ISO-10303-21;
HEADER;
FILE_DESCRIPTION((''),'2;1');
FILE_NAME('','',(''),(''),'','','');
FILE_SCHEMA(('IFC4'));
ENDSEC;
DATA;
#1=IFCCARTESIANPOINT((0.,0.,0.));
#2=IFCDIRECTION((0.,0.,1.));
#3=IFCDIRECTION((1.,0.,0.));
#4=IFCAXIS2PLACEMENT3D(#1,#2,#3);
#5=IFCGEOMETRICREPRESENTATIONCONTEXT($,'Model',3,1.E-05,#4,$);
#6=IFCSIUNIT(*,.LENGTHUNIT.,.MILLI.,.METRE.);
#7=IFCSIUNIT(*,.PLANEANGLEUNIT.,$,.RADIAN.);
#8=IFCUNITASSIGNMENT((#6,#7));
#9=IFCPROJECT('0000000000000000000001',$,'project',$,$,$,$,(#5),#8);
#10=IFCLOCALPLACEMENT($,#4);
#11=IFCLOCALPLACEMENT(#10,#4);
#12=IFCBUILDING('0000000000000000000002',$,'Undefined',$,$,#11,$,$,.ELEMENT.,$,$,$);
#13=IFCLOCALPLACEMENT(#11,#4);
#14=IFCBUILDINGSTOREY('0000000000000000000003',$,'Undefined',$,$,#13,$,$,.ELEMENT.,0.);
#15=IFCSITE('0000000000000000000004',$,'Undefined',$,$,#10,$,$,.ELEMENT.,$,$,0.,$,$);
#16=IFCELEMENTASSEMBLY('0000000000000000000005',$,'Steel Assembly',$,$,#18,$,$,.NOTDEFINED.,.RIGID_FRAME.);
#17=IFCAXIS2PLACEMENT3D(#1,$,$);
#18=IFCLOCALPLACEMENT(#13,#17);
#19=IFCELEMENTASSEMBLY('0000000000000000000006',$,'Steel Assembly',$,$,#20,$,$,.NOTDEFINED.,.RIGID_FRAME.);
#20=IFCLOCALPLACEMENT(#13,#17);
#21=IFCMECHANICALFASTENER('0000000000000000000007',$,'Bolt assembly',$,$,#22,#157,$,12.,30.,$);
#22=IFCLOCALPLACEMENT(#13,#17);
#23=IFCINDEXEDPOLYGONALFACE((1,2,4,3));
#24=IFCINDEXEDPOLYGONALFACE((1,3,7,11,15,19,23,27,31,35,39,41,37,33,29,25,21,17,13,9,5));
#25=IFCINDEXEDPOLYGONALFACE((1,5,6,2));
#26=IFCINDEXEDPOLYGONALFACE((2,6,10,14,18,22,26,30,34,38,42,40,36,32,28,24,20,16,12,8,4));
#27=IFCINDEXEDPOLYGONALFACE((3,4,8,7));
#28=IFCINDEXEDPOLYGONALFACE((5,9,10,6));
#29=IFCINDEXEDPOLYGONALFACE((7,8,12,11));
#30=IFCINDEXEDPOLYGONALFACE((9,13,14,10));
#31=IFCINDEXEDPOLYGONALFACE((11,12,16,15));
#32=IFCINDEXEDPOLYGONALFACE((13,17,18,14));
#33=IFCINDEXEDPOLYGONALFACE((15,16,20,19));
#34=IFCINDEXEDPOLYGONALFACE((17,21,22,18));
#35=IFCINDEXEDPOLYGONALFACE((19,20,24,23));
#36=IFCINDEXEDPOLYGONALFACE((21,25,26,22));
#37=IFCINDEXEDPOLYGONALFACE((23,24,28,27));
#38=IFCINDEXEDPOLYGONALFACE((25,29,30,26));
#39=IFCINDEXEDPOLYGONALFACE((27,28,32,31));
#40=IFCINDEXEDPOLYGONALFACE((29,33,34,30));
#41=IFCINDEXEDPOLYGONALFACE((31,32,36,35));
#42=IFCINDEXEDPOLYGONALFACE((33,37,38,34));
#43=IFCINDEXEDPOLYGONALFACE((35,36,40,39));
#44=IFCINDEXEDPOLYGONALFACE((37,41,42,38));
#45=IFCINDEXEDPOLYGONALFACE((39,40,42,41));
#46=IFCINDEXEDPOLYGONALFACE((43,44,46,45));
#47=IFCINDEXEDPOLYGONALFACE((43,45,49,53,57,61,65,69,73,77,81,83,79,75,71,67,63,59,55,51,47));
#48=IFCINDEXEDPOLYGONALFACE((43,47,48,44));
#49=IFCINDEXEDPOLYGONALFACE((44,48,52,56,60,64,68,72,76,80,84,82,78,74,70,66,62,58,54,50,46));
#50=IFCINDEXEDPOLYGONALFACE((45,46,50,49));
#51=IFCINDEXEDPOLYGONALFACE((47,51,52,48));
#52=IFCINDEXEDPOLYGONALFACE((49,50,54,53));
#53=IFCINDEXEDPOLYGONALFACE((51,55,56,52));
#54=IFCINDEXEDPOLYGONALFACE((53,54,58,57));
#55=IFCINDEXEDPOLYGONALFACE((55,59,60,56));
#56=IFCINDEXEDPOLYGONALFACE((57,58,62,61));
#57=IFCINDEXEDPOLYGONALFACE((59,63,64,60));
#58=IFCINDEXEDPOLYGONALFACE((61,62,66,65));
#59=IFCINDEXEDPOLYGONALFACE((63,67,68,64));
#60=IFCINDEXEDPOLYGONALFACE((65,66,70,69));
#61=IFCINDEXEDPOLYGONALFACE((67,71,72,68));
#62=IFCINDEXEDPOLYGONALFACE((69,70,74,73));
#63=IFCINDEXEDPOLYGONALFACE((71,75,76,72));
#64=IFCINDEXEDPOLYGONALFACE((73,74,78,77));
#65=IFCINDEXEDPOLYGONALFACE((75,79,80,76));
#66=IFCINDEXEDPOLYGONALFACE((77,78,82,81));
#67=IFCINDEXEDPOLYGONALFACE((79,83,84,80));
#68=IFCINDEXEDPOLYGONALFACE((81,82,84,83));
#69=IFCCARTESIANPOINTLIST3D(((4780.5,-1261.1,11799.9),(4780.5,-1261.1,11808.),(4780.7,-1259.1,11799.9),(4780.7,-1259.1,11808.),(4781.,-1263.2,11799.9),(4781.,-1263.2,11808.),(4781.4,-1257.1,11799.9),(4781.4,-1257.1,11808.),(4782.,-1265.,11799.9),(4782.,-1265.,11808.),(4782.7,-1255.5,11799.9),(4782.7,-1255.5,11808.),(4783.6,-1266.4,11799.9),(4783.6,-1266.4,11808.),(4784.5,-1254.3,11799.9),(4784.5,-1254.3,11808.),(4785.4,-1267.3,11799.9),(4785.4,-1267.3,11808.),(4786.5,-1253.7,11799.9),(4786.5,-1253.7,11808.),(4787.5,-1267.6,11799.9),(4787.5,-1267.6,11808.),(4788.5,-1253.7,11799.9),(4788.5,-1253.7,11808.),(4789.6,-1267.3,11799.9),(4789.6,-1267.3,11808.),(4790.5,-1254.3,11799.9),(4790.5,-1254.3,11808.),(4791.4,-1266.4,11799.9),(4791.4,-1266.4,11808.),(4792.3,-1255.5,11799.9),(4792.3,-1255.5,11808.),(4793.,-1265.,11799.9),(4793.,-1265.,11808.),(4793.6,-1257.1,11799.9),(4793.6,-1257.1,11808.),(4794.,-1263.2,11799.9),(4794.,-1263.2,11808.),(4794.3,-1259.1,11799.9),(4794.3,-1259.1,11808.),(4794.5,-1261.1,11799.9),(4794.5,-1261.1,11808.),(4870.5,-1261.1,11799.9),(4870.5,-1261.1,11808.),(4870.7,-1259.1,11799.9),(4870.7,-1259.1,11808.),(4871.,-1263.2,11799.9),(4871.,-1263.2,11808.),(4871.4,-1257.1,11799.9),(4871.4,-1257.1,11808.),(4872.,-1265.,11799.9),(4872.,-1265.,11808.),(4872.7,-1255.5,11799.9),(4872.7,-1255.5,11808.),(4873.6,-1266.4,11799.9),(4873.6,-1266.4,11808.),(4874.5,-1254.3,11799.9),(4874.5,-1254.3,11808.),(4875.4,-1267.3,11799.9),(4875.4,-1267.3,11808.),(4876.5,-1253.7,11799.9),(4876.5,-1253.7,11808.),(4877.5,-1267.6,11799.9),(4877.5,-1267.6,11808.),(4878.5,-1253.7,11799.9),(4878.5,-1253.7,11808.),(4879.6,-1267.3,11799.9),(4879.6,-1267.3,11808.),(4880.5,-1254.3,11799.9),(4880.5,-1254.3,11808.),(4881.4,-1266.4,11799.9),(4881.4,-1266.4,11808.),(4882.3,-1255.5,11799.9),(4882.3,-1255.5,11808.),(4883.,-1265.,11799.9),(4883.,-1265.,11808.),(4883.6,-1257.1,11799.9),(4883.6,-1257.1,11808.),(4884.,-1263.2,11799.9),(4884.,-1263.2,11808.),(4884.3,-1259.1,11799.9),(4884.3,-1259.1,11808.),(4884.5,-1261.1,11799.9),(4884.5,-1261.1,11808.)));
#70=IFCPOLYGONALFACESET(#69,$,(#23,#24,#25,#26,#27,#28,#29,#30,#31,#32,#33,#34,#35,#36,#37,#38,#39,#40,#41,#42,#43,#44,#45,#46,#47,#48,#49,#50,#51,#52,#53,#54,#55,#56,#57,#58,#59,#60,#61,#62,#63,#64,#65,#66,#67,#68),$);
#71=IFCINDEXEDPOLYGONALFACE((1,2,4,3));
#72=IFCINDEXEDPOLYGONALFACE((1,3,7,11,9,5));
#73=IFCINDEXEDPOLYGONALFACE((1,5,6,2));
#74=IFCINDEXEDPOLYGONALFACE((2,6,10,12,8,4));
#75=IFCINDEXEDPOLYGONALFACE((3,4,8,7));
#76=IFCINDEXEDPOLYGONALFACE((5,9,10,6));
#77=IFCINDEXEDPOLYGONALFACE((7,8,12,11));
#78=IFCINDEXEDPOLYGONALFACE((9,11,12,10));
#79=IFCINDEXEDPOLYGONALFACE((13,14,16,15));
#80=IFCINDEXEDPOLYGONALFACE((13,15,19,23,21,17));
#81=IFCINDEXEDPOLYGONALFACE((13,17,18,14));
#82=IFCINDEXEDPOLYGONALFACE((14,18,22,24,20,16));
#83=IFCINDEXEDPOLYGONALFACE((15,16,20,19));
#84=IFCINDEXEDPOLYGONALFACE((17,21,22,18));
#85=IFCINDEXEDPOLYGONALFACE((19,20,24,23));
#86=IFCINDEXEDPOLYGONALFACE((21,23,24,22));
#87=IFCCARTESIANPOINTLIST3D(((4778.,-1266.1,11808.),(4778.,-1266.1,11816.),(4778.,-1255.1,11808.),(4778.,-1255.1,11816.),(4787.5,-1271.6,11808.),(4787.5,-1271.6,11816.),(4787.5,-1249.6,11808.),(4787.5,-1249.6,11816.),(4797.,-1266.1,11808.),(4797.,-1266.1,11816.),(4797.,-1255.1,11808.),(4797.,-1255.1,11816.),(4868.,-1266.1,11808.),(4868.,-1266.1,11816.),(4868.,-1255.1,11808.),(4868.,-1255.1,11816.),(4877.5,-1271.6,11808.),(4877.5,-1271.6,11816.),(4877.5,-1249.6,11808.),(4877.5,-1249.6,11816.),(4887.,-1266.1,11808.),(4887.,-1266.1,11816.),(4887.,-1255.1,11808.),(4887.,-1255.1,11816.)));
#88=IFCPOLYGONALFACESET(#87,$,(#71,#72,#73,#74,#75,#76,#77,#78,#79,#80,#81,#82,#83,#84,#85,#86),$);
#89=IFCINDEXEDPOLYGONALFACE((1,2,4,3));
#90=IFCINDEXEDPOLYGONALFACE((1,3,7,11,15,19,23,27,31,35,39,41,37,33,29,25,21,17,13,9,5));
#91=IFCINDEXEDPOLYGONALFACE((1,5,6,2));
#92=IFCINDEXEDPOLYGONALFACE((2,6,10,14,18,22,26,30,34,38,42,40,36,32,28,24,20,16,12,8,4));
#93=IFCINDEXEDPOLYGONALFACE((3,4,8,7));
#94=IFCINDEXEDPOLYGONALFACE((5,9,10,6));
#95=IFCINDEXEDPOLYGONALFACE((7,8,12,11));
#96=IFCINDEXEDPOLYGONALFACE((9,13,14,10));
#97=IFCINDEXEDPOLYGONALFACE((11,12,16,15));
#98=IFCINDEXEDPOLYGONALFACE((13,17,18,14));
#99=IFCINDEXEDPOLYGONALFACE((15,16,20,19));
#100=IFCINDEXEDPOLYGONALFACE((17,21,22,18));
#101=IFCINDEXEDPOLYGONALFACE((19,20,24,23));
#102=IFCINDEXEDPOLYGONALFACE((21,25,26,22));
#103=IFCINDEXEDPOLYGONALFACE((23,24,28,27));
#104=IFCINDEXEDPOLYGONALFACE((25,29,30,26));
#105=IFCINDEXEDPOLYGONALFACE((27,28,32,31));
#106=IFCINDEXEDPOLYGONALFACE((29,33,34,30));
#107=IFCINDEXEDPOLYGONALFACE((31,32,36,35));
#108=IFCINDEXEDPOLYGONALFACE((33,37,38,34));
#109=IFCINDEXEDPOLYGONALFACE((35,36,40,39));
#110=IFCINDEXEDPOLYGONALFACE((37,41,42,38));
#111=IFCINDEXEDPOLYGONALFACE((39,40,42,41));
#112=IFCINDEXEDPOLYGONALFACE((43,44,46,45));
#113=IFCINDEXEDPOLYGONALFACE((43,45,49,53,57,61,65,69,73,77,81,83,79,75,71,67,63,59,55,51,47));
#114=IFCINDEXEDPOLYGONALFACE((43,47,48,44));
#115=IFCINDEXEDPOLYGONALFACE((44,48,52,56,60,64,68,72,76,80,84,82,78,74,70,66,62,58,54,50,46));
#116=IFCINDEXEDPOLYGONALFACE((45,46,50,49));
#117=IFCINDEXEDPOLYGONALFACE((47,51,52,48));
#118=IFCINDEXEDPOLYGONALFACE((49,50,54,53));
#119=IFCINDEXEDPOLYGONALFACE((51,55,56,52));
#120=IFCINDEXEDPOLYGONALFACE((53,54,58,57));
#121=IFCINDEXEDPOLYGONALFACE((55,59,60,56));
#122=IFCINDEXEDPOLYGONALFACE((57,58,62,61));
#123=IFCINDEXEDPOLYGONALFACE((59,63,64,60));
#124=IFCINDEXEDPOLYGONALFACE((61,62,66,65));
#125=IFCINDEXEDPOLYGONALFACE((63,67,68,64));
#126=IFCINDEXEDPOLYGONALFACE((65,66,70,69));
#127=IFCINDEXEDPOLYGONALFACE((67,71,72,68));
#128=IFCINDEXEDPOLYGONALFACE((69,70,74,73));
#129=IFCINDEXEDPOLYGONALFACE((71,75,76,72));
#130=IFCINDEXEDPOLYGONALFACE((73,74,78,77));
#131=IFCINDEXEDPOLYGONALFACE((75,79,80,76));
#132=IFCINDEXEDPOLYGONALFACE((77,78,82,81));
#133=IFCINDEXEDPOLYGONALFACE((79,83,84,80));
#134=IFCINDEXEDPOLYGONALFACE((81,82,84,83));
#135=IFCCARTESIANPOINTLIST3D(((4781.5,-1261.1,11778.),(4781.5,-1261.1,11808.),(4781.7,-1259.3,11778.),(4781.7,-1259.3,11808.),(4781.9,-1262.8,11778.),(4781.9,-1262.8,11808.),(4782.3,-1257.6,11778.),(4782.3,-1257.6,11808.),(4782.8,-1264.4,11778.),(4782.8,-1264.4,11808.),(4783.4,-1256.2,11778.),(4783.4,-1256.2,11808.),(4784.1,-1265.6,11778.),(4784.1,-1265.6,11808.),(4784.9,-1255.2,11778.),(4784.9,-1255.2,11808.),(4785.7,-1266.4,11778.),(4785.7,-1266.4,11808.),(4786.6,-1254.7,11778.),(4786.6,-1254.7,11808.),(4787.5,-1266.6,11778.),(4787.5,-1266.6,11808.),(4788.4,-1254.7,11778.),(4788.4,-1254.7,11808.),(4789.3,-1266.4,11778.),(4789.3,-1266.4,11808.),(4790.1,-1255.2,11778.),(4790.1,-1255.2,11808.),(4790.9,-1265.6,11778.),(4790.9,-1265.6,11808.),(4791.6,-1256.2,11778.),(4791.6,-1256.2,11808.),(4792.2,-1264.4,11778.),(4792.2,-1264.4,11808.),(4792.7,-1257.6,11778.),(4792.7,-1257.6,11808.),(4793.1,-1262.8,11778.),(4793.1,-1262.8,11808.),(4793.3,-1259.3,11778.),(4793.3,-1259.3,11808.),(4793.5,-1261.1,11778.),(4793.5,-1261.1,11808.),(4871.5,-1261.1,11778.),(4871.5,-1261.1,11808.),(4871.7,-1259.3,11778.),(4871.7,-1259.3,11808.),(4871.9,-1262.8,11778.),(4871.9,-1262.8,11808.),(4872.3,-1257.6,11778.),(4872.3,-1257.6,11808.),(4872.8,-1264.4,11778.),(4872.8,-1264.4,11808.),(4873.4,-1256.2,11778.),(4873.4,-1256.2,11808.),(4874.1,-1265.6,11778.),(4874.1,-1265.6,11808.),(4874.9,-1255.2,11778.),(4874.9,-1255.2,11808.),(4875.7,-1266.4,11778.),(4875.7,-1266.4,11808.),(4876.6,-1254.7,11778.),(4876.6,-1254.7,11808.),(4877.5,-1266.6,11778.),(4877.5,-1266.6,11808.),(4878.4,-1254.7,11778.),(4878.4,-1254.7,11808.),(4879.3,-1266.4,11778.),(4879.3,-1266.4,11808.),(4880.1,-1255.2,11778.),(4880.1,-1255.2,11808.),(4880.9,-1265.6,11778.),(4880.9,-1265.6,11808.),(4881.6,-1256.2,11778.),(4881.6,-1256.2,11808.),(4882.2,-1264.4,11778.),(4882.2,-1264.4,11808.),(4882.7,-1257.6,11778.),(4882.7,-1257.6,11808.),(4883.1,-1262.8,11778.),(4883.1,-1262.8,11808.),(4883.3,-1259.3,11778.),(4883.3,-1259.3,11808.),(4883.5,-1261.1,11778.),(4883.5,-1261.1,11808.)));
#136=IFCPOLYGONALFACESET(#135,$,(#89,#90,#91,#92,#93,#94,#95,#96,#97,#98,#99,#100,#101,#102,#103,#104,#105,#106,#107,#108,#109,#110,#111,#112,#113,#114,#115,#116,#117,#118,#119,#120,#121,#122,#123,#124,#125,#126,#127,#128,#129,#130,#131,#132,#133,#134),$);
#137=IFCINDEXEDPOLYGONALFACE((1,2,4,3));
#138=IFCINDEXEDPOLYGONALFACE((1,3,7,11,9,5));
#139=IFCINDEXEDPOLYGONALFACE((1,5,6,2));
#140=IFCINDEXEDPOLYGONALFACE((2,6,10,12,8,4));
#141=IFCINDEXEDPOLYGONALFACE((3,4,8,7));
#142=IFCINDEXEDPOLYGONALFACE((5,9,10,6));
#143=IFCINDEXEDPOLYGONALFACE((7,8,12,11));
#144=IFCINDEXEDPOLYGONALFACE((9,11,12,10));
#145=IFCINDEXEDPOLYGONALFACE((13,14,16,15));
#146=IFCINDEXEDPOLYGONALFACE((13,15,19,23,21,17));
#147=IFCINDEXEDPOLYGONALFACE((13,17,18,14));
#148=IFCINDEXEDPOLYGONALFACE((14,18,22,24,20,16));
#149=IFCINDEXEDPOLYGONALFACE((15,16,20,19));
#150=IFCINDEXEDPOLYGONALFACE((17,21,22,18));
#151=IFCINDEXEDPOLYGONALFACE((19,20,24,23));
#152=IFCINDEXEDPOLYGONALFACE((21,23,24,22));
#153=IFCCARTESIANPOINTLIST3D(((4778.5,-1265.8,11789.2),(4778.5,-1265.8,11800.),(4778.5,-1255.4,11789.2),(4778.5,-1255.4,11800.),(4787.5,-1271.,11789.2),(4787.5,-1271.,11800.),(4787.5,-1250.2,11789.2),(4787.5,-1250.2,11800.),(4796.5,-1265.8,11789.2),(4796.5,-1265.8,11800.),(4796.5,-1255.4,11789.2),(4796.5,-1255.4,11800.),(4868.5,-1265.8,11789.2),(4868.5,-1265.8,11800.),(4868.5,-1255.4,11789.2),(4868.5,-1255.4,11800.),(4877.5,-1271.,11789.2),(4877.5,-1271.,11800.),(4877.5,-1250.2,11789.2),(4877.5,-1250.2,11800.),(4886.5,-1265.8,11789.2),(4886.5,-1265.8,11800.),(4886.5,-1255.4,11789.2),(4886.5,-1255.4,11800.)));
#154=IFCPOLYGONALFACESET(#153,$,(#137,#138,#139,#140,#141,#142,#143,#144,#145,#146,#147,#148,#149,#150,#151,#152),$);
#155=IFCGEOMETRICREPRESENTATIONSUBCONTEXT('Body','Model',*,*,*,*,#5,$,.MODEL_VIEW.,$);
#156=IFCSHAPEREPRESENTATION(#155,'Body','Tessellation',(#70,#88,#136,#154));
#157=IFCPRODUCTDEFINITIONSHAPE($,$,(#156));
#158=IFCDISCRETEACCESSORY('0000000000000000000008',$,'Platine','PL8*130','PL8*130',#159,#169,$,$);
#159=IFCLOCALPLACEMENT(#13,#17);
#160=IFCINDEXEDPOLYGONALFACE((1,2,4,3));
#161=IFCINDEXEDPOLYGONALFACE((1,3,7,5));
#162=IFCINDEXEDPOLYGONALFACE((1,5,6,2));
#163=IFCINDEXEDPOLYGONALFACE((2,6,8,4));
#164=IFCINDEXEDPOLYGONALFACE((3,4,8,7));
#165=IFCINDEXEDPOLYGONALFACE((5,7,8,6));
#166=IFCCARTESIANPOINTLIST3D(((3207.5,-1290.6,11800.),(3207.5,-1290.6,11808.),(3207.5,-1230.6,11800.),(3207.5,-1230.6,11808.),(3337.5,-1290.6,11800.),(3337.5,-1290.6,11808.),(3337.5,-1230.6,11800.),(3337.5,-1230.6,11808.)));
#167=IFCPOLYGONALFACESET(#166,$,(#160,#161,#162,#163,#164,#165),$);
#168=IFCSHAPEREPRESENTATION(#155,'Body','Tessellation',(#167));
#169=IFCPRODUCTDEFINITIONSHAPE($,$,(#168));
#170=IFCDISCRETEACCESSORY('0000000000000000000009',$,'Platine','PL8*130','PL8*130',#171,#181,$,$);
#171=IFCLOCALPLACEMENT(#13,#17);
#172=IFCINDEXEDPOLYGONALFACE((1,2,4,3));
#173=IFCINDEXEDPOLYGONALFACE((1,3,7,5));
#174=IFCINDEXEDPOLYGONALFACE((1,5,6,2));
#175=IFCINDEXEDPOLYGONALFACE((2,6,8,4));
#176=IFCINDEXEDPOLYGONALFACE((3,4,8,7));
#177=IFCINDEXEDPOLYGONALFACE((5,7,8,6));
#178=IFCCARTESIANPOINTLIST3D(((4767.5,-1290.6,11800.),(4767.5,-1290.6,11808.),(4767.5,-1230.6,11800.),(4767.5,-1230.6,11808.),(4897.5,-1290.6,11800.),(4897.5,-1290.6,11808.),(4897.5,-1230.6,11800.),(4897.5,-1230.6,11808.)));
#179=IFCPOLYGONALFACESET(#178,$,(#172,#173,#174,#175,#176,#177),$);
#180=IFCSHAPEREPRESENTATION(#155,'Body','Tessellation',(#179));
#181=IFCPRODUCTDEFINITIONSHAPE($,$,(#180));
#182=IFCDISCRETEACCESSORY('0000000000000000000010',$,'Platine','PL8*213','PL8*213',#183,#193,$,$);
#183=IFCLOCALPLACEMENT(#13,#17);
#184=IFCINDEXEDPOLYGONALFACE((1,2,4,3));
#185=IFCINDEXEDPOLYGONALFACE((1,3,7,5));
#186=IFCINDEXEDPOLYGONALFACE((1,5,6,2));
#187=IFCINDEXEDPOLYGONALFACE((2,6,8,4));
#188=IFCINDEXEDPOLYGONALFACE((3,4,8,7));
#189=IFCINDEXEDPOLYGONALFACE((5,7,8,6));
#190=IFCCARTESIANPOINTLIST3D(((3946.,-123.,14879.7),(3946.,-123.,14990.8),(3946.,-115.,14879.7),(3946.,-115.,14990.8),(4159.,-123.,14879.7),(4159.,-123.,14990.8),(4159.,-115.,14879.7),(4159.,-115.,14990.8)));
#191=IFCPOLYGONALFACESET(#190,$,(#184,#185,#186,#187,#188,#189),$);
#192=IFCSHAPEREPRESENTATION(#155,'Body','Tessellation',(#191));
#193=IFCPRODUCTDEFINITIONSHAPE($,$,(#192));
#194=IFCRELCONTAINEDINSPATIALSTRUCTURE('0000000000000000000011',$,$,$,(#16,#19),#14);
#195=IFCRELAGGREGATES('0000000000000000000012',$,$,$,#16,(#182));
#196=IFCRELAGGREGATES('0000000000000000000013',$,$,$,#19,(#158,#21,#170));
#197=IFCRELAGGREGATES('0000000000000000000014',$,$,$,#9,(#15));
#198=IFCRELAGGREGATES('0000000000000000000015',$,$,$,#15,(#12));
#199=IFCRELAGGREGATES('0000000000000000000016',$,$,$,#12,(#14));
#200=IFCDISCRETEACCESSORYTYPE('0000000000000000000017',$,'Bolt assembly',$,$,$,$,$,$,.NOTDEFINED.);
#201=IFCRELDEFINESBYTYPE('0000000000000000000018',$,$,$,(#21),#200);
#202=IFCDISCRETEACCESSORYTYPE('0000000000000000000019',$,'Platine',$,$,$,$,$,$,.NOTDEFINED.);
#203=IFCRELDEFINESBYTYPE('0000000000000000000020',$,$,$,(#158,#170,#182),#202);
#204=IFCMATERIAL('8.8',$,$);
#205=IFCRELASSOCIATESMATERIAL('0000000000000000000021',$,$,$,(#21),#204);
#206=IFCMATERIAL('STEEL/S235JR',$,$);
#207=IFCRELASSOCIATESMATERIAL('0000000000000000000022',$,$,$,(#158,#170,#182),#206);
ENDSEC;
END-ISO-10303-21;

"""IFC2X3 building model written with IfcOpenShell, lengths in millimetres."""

from ifc_helpers import new_model, si_unit, frame, origin_with_axes, origin_2d_with_axis, place, context, subcontext, project, spatial, polyline, circle, outline, extrude, source, transform, mapped, material, type_object, element, aggregate, save


model = new_model("IFC2X3")

# Units and contexts
model_context = context("Model", 3, precision=1e-05, world=origin_with_axes())
body_context = subcontext(model_context, "Body", "Model", "MODEL_VIEW")
ifc_project = project(units=[si_unit("LENGTHUNIT", "METRE", prefix="MILLI"), si_unit("PLANEANGLEUNIT", "RADIAN")], contexts=[model_context])

# Site, building, storey
site_placement = place(None, origin_with_axes())
site = spatial("IfcSite", under=ifc_project, at=site_placement, Name="Undefined", CompositionType="ELEMENT", RefElevation=0.0)
building_placement = place(site_placement, origin_with_axes())
building = spatial("IfcBuilding", under=site, at=building_placement, Name="Undefined", CompositionType="ELEMENT")
storey_placement = place(building_placement, origin_with_axes())
storey = spatial("IfcBuildingStorey", under=building, at=storey_placement, Name="Undefined", CompositionType="ELEMENT", Elevation=0.0)

# Element assembly
ifc_material_1 = material(Name="STEEL/S235JR")
assembly_1_placement = place(storey_placement, origin_with_axes())
assembly_1 = element("IfcElementAssembly", 1, at=assembly_1_placement, inside=storey, Name="Steel Assembly", AssemblyPlace="NOTDEFINED", PredefinedType="RIGID_FRAME")

# Element assembly, mechanical fastener, discrete accessories
assembly_2_placement = place(storey_placement, origin_with_axes())
assembly_2 = element("IfcElementAssembly", 2, at=assembly_2_placement, inside=storey, Name="Steel Assembly", AssemblyPlace="NOTDEFINED", PredefinedType="RIGID_FRAME")
ifc_material_2 = material(Name="8.8")
discrete_accessory_type_1 = type_object("IfcDiscreteAccessoryType", Name="Bolt assembly")
shared_shape_1 = source(origin_with_axes(), body_context, "Body", "SweptSolid", [
    extrude(circle(Radius=7.0, at=origin_2d_with_axis()), frame((0.0, 0.0, 0.0), z_axis=(0.0, 1.0, 0.0), x_axis=(1.0, 0.0, 0.0)), (0.0, 0.0, 1.0), 8.1),
    extrude(outline(polyline([(11.0, 0.0), (5.5, 9.5), (-5.5, 9.5), (-11.0, 0.0), (-5.5, -9.5), (5.5, -9.5), (11.0, 0.0)])), frame((0.0, -8.0, 0.0), z_axis=(0.0, 1.0, 0.0), x_axis=(1.0, 0.0, 0.0)), (0.0, 0.0, 1.0), 8.0),
    extrude(circle(Radius=6.0, at=origin_2d_with_axis()), frame((0.0, 0.0, 0.0), z_axis=(0.0, 1.0, 0.0), x_axis=(1.0, 0.0, 0.0)), (0.0, 0.0, 1.0), 30.0),
    extrude(outline(polyline([(10.4, 0.0), (5.2, 9.0), (-5.2, 9.0), (-10.4, 0.0), (-5.2, -9.0), (5.2, -9.0), (10.4, 0.0)])), frame((0.0, 8.0, 0.0), z_axis=(0.0, 1.0, 0.0), x_axis=(1.0, 0.0, 0.0)), (0.0, 0.0, 1.0), 10.8),
])
mechanical_fastener_1_placement = place(assembly_2_placement, frame((4832.5, -1240.6, 11808.0), z_axis=(1.0, 0.0, 0.0), x_axis=(0.0, -1.0, 0.0)))
mechanical_fastener_1 = element("IfcMechanicalFastener", 3, at=mechanical_fastener_1_placement, type_object=discrete_accessory_type_1, material=ifc_material_2, Name="Bolt assembly", NominalDiameter=12.0, NominalLength=30.0, context=body_context, shape_type="MappedRepresentation", body=[
    mapped(shared_shape_1, transform((20.0, 0.0, -45.0))),
    mapped(shared_shape_1, transform((20.0, 0.0, 45.0))),
])
discrete_accessory_type_2 = type_object("IfcDiscreteAccessoryType", Name="Platine")
discrete_accessory_1_placement = place(assembly_2_placement, frame((3272.5, -1290.6, 11804.0), z_axis=(0.0, 0.0, 1.0), x_axis=(0.0, 1.0, 0.0)))
discrete_accessory_1 = element("IfcDiscreteAccessory", 4, at=discrete_accessory_1_placement, type_object=discrete_accessory_type_2, material=ifc_material_1, Name="Platine", Description="PL8*130", ObjectType="PL8*130", context=body_context, shape_type="SweptSolid", body=[
    extrude(outline(polyline([(60.0, 65.0), (60.0, -65.0), (0.0, -65.0), (0.0, 65.0), (60.0, 65.0)])), frame((0.0, 0.0, -4.0), z_axis=(0.0, 0.0, 1.0), x_axis=(1.0, 0.0, 0.0)), (0.0, 0.0, 1.0), 8.0),
])
discrete_accessory_2_placement = place(assembly_2_placement, frame((4832.5, -1290.6, 11804.0), z_axis=(0.0, 0.0, 1.0), x_axis=(0.0, 1.0, 0.0)))
discrete_accessory_2 = element("IfcDiscreteAccessory", 5, at=discrete_accessory_2_placement, type_object=discrete_accessory_type_2, material=ifc_material_1, Name="Platine", Description="PL8*130", ObjectType="PL8*130", context=body_context, shape_type="SweptSolid", body=[
    extrude(outline(polyline([(60.0, 65.0), (60.0, -65.0), (0.0, -65.0), (0.0, 65.0), (60.0, 65.0)])), frame((0.0, 0.0, -4.0), z_axis=(0.0, 0.0, 1.0), x_axis=(1.0, 0.0, 0.0)), (0.0, 0.0, 1.0), 8.0),
])

# Discrete accessory
discrete_accessory_3_placement = place(assembly_1_placement, frame((4052.5, -119.0, 14879.7), z_axis=(0.0, -1.0, 0.0), x_axis=(0.0, 0.0, 1.0)))
discrete_accessory_3 = element("IfcDiscreteAccessory", 6, at=discrete_accessory_3_placement, type_object=discrete_accessory_type_2, material=ifc_material_1, Name="Platine", Description="PL8*213", ObjectType="PL8*213", context=body_context, shape_type="SweptSolid", body=[
    extrude(outline(polyline([(111.1, 106.5), (111.1, -106.5), (0.0, -106.5), (0.0, 106.5), (111.1, 106.5)])), frame((0.0, 0.0, -4.0), z_axis=(0.0, 0.0, 1.0), x_axis=(1.0, 0.0, 0.0)), (0.0, 0.0, 1.0), 8.0),
])

aggregate(assembly_1, [discrete_accessory_3])

aggregate(assembly_2, [discrete_accessory_1, mechanical_fastener_1, discrete_accessory_2])

save(model, "model.ifc")
